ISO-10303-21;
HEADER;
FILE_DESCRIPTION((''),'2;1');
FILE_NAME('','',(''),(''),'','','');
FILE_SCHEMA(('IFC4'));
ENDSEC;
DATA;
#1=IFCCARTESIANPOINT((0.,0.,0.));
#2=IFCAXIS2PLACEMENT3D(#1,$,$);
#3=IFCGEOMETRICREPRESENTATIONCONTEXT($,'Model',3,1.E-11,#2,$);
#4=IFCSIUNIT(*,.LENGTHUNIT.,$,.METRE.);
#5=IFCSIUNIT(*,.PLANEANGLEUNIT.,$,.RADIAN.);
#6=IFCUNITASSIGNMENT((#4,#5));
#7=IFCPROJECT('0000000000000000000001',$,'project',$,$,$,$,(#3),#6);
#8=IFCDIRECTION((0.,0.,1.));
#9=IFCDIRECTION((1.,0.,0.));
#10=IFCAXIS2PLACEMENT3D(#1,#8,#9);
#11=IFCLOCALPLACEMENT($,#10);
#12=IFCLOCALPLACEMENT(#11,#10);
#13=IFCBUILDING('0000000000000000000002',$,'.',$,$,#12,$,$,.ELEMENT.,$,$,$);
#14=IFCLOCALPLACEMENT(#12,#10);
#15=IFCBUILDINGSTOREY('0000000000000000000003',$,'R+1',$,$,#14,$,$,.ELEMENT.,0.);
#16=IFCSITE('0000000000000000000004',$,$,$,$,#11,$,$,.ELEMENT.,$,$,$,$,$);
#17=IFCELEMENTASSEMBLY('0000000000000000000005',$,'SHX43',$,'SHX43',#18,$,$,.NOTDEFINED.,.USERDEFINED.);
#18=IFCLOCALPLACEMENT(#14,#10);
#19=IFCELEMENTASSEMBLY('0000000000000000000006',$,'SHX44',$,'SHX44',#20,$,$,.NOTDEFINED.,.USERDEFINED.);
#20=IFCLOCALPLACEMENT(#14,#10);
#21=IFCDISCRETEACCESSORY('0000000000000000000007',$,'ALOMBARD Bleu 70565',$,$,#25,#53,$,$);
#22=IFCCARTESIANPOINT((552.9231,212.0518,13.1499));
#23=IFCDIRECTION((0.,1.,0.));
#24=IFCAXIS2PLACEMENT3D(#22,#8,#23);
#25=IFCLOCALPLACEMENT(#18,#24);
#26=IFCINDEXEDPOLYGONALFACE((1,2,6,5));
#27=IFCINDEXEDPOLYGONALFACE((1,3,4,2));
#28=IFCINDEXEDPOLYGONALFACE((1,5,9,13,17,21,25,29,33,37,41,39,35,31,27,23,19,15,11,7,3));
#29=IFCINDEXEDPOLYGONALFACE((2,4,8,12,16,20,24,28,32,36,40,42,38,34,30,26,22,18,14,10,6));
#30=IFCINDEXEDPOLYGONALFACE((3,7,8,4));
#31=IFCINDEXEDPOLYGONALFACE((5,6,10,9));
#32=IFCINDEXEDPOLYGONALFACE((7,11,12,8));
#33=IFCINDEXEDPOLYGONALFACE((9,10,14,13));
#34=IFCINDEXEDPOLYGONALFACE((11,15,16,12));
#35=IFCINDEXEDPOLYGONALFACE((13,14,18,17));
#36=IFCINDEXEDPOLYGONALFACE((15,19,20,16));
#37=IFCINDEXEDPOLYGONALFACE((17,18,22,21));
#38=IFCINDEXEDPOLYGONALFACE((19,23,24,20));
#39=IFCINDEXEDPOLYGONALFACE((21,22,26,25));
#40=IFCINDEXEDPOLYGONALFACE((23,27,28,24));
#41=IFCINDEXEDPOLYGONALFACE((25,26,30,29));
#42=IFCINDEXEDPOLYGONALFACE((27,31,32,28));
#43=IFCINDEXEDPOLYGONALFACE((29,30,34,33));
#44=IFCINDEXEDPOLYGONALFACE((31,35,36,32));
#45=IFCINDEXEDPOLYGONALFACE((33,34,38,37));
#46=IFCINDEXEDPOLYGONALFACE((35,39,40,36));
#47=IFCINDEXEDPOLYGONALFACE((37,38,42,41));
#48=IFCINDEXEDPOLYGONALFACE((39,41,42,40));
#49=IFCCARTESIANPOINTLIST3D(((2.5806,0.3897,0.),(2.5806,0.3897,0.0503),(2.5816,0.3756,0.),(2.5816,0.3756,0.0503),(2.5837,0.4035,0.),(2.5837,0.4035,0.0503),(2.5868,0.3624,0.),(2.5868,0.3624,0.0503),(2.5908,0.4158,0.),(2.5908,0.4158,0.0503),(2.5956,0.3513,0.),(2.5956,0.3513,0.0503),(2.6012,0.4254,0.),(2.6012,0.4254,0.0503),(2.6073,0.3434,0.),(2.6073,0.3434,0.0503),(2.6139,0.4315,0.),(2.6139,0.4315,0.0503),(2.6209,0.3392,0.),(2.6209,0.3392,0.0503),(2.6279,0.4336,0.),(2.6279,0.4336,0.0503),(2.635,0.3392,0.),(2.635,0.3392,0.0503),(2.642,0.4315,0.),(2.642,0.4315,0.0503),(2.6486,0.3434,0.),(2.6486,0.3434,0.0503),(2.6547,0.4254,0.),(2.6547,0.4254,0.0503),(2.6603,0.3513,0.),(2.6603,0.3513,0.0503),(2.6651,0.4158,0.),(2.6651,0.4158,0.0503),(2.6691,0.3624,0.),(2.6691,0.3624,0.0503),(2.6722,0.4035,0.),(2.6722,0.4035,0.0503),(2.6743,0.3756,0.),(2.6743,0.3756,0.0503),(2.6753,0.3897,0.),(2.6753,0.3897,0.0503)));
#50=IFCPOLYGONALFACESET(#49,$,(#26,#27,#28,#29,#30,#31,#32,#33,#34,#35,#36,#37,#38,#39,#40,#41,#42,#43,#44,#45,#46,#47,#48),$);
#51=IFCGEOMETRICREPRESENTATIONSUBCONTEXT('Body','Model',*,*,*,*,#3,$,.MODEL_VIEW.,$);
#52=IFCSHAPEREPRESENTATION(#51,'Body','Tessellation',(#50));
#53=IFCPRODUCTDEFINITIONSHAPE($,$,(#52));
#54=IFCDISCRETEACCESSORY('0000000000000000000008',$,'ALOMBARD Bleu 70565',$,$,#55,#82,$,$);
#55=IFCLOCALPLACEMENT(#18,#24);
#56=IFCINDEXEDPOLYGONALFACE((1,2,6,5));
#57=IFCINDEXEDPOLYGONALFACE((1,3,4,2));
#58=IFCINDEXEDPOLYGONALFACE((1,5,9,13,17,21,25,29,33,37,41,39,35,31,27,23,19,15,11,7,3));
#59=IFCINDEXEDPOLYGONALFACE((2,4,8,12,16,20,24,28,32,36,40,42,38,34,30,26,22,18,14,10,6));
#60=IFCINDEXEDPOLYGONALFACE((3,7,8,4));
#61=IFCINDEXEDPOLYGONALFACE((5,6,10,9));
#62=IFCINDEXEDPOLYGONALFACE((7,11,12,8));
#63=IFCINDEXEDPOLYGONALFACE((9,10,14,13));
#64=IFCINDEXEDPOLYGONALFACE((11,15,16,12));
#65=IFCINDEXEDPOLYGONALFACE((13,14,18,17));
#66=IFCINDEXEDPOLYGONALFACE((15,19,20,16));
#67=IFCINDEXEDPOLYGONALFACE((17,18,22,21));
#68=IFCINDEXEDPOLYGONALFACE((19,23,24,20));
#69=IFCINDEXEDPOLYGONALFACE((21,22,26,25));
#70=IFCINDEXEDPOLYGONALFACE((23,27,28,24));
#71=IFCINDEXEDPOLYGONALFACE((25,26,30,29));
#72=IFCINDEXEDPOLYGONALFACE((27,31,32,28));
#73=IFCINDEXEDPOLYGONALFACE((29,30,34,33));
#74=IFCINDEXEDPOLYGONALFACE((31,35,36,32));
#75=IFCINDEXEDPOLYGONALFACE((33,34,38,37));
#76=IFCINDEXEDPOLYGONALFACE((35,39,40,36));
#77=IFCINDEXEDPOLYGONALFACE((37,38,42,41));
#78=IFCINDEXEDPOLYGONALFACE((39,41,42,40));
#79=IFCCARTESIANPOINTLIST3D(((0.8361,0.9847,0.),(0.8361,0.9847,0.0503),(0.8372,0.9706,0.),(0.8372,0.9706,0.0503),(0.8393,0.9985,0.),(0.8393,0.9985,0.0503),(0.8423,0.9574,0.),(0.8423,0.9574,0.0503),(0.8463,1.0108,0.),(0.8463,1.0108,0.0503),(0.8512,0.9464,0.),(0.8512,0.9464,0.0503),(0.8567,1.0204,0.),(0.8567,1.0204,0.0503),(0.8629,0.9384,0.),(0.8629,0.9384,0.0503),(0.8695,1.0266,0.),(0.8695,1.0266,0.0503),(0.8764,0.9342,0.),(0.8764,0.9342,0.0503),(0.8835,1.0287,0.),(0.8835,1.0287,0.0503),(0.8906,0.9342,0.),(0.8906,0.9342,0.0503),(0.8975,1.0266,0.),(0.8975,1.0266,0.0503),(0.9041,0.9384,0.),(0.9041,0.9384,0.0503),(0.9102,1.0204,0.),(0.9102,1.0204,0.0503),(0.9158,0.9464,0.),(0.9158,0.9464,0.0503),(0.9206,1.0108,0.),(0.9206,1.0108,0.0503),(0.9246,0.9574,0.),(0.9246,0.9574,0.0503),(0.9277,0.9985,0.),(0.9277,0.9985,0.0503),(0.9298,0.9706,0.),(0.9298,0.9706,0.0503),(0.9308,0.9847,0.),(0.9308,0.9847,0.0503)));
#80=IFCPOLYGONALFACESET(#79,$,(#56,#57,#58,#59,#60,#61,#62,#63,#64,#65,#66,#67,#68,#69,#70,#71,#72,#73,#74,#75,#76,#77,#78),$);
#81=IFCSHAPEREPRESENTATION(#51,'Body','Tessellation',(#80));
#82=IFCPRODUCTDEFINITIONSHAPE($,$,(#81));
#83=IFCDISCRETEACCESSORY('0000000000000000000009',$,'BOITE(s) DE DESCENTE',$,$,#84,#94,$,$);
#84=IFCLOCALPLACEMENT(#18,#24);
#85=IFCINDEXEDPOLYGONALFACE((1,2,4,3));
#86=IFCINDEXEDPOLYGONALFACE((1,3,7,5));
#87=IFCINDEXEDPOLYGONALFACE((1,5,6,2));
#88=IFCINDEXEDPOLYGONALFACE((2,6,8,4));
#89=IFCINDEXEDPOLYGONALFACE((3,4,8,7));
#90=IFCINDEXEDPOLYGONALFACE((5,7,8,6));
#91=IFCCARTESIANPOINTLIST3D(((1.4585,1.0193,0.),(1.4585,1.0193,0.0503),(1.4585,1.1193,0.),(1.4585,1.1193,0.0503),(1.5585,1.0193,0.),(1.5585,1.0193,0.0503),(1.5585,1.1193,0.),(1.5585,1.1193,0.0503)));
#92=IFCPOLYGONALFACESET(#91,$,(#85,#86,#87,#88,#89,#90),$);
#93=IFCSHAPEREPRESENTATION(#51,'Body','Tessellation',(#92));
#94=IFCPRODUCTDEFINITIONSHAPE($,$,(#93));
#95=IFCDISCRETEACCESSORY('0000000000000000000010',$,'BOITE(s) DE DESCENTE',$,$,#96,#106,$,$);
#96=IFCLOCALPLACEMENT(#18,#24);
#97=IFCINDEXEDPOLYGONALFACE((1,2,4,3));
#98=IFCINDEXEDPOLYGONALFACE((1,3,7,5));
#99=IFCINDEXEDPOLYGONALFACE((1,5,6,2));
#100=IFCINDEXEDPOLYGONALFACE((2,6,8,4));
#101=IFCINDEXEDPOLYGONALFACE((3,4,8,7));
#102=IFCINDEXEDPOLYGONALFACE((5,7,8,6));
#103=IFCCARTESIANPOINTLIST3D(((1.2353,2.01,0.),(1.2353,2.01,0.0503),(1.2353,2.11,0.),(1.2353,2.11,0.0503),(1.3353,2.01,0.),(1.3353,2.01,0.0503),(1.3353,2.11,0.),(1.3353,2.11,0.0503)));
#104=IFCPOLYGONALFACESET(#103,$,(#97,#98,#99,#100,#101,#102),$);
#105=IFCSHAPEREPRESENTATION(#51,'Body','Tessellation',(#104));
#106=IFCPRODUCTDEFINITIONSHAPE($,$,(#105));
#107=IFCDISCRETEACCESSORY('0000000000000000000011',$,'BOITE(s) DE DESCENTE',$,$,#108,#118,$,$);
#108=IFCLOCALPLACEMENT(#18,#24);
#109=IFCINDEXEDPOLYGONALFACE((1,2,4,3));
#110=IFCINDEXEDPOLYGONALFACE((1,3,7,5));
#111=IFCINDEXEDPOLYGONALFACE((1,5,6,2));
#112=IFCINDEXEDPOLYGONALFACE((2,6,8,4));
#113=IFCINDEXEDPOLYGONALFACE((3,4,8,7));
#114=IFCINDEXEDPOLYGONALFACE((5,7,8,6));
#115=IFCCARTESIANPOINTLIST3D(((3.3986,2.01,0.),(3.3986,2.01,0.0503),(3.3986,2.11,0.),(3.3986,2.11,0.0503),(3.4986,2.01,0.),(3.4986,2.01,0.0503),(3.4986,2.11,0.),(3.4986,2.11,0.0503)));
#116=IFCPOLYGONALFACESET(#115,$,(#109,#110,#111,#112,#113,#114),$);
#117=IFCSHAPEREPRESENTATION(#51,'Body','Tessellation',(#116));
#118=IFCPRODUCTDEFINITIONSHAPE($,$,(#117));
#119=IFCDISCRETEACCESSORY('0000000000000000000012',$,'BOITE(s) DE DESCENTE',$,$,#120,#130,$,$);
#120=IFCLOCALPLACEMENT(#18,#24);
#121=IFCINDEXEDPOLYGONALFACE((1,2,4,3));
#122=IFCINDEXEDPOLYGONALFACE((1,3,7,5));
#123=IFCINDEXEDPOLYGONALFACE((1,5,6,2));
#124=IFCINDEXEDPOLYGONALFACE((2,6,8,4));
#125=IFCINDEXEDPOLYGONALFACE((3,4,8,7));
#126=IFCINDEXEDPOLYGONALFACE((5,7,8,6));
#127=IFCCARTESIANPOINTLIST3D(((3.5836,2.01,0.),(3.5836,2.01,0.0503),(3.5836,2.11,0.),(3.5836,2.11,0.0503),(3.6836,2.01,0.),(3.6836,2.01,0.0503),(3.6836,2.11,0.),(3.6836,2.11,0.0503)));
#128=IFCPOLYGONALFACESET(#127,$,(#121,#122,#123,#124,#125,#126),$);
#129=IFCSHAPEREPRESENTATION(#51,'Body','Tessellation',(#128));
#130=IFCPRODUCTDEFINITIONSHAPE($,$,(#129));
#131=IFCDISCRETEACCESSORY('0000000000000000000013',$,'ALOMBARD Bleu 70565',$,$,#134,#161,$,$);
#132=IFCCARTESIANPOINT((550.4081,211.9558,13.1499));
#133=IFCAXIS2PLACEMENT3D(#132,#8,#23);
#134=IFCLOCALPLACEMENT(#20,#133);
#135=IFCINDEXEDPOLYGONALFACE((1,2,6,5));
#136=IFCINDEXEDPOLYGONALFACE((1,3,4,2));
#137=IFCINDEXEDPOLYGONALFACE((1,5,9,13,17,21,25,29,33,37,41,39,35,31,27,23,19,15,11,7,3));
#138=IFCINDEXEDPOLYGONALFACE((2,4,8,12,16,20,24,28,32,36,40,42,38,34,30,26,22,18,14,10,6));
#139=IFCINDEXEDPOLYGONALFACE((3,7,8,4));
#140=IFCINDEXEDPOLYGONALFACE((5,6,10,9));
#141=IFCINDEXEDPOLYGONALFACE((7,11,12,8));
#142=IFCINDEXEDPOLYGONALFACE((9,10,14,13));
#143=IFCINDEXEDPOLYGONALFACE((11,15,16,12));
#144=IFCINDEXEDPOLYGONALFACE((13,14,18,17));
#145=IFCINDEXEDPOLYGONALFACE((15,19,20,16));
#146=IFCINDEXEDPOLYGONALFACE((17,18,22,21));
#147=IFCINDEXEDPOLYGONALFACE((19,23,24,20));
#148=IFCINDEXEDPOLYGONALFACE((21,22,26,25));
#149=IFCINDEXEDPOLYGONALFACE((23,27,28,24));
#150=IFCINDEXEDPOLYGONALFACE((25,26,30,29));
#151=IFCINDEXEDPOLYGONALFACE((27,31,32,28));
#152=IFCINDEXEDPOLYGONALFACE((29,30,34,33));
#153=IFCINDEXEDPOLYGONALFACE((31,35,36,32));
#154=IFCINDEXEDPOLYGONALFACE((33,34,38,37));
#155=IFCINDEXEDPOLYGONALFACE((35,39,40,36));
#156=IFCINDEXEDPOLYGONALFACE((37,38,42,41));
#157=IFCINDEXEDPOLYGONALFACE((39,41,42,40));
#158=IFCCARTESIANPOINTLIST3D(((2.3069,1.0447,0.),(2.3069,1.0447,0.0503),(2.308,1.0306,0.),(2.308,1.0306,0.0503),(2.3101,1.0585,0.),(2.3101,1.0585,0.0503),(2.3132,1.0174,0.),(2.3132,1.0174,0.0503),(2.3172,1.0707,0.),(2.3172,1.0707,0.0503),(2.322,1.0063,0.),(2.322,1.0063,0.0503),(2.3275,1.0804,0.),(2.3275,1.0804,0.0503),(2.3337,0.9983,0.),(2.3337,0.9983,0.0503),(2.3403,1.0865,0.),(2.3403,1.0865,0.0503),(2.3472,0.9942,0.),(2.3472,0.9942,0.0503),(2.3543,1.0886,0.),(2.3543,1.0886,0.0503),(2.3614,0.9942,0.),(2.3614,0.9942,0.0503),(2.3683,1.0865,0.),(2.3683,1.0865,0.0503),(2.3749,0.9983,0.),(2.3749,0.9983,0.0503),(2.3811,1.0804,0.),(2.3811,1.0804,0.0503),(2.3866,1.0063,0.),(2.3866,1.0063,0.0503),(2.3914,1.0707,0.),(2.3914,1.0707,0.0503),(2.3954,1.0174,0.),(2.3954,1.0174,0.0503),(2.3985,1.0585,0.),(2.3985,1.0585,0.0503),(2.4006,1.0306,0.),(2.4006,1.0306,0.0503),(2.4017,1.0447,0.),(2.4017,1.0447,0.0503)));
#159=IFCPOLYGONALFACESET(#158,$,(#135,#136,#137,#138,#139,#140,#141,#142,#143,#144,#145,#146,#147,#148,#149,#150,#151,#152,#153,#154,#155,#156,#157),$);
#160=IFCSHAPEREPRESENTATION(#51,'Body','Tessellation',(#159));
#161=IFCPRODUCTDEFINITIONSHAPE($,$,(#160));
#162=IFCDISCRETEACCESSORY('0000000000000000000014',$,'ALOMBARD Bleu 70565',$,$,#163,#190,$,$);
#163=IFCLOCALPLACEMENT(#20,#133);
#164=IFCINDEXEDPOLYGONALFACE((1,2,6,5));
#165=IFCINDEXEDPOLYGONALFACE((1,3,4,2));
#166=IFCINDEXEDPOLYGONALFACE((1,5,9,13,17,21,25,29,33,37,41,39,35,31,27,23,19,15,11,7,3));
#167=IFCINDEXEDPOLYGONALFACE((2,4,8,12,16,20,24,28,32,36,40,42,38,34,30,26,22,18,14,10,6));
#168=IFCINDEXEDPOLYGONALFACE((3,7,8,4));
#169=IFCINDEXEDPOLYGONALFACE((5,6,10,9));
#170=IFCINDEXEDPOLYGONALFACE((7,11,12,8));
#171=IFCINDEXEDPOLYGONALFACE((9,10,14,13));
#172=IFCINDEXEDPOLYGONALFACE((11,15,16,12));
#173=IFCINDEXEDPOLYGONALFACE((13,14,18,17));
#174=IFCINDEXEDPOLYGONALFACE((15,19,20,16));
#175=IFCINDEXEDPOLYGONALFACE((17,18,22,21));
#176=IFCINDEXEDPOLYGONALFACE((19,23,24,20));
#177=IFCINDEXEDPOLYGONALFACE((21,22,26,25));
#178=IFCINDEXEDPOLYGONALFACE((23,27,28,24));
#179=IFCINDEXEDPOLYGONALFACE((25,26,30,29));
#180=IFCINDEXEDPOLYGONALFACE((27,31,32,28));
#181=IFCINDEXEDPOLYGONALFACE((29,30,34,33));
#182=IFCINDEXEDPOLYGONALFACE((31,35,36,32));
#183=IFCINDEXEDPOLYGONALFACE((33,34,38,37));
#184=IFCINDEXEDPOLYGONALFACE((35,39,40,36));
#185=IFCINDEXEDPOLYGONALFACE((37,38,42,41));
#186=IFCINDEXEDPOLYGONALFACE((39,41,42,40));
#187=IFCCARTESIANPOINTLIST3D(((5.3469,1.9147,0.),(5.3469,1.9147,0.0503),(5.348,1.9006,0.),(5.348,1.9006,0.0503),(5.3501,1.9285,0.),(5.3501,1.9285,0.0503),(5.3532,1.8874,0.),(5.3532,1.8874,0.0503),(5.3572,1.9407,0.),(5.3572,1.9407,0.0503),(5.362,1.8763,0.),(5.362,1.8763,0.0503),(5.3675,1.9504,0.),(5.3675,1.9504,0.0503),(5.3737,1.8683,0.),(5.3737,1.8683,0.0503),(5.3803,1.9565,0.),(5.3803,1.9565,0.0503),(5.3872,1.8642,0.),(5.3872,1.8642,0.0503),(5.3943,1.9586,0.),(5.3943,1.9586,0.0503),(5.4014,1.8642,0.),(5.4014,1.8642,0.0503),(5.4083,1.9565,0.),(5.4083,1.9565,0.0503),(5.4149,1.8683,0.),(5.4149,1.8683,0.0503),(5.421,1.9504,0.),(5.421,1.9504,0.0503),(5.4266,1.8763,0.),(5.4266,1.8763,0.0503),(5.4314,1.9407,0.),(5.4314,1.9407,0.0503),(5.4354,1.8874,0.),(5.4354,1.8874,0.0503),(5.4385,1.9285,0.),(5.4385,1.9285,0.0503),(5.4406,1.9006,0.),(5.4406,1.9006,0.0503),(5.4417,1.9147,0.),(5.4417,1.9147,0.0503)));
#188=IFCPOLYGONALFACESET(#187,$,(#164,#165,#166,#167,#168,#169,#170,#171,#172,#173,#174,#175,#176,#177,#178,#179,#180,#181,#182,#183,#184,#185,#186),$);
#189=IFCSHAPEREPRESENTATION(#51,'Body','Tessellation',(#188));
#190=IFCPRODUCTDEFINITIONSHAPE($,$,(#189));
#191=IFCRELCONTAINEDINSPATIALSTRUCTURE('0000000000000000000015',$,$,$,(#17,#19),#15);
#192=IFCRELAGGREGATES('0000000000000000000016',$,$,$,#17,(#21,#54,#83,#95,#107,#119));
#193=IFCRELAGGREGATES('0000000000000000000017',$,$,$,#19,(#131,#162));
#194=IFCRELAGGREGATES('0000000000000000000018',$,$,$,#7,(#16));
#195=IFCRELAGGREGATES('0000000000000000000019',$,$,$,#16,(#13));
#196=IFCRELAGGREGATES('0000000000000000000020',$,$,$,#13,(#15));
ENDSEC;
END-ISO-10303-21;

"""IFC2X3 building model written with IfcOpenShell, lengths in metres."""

from ifc_helpers import new_model, si_unit, frame, frame_2d, origin, origin_with_axes, place, context, subcontext, project, spatial, polyline, circle, outline, extrude, element, aggregate, save


model = new_model("IFC2X3")

# Units and contexts
model_context = context("Model", 3, precision=1e-11, world=origin())
body_context = subcontext(model_context, "Body", "Model", "MODEL_VIEW")
ifc_project = project(units=[si_unit("LENGTHUNIT", "METRE"), si_unit("PLANEANGLEUNIT", "RADIAN")], contexts=[model_context])

# Site, building, storey
site_placement = place(None, origin_with_axes())
site = spatial("IfcSite", under=ifc_project, at=site_placement, CompositionType="ELEMENT")
building_placement = place(site_placement, origin_with_axes())
building = spatial("IfcBuilding", under=site, at=building_placement, Name=".", CompositionType="ELEMENT")
storey_placement = place(building_placement, origin_with_axes())
storey = spatial("IfcBuildingStorey", under=building, at=storey_placement, Name="R+1", CompositionType="ELEMENT", Elevation=0.0)

# Element assemblies
assembly_1_placement = place(storey_placement, origin_with_axes())
assembly_1 = element("IfcElementAssembly", 1, at=assembly_1_placement, inside=storey, Name="SHX43", ObjectType="SHX43", AssemblyPlace="NOTDEFINED", PredefinedType="USERDEFINED")
assembly_2_placement = place(storey_placement, origin_with_axes())
assembly_2 = element("IfcElementAssembly", 2, at=assembly_2_placement, inside=storey, Name="SHX44", ObjectType="SHX44", AssemblyPlace="NOTDEFINED", PredefinedType="USERDEFINED")

# Discrete accessories
discrete_accessory_1_placement = place(assembly_1_placement, frame((552.9231, 212.0518, 13.1499), z_axis=(0.0, 0.0, 1.0), x_axis=(0.0, 1.0, 0.0)))
discrete_accessory_1 = element("IfcDiscreteAccessory", 3, at=discrete_accessory_1_placement, Name="ALOMBARD Bleu 70565", context=body_context, shape_type="SweptSolid", body=[
    extrude(circle(Radius=0.0475, at=frame_2d((0.3861, -2.6279), x_axis=(1.0, 0.0))), frame((0.0, 0.0, 0.0), z_axis=(0.0, 0.0, 1.0), x_axis=(0.0, 1.0, 0.0)), (0.0, 0.0, 1.0), 0.0503),
])
discrete_accessory_2_placement = place(assembly_1_placement, frame((552.9231, 212.0518, 13.1499), z_axis=(0.0, 0.0, 1.0), x_axis=(0.0, 1.0, 0.0)))
discrete_accessory_2 = element("IfcDiscreteAccessory", 4, at=discrete_accessory_2_placement, Name="ALOMBARD Bleu 70565", context=body_context, shape_type="SweptSolid", body=[
    extrude(circle(Radius=0.0475, at=frame_2d((0.9812, -0.8835), x_axis=(1.0, 0.0))), frame((0.0, 0.0, 0.0), z_axis=(0.0, 0.0, 1.0), x_axis=(0.0, 1.0, 0.0)), (0.0, 0.0, 1.0), 0.0503),
])
discrete_accessory_3_placement = place(assembly_1_placement, frame((552.9231, 212.0518, 13.1499), z_axis=(0.0, 0.0, 1.0), x_axis=(0.0, 1.0, 0.0)))
discrete_accessory_3 = element("IfcDiscreteAccessory", 5, at=discrete_accessory_3_placement, Name="BOITE(s) DE DESCENTE", context=body_context, shape_type="SweptSolid", body=[
    extrude(outline(polyline([(1.0193, -1.4585), (1.0193, -1.5585), (1.1193, -1.5585), (1.1193, -1.4585), (1.0193, -1.4585)])), frame((0.0, 0.0, 0.0), z_axis=(0.0, 0.0, 1.0), x_axis=(0.0, 1.0, 0.0)), (0.0, 0.0, 1.0), 0.0503),
])
discrete_accessory_4_placement = place(assembly_1_placement, frame((552.9231, 212.0518, 13.1499), z_axis=(0.0, 0.0, 1.0), x_axis=(0.0, 1.0, 0.0)))
discrete_accessory_4 = element("IfcDiscreteAccessory", 6, at=discrete_accessory_4_placement, Name="BOITE(s) DE DESCENTE", context=body_context, shape_type="SweptSolid", body=[
    extrude(outline(polyline([(2.01, -1.2353), (2.01, -1.3353), (2.11, -1.3353), (2.11, -1.2353), (2.01, -1.2353)])), frame((0.0, 0.0, 0.0), z_axis=(0.0, 0.0, 1.0), x_axis=(0.0, 1.0, 0.0)), (0.0, 0.0, 1.0), 0.0503),
])
discrete_accessory_5_placement = place(assembly_1_placement, frame((552.9231, 212.0518, 13.1499), z_axis=(0.0, 0.0, 1.0), x_axis=(0.0, 1.0, 0.0)))
discrete_accessory_5 = element("IfcDiscreteAccessory", 7, at=discrete_accessory_5_placement, Name="BOITE(s) DE DESCENTE", context=body_context, shape_type="SweptSolid", body=[
    extrude(outline(polyline([(2.01, -3.3986), (2.01, -3.4986), (2.11, -3.4986), (2.11, -3.3986), (2.01, -3.3986)])), frame((0.0, 0.0, 0.0), z_axis=(0.0, 0.0, 1.0), x_axis=(0.0, 1.0, 0.0)), (0.0, 0.0, 1.0), 0.0503),
])
discrete_accessory_6_placement = place(assembly_1_placement, frame((552.9231, 212.0518, 13.1499), z_axis=(0.0, 0.0, 1.0), x_axis=(0.0, 1.0, 0.0)))
discrete_accessory_6 = element("IfcDiscreteAccessory", 8, at=discrete_accessory_6_placement, Name="BOITE(s) DE DESCENTE", context=body_context, shape_type="SweptSolid", body=[
    extrude(outline(polyline([(2.01, -3.5836), (2.01, -3.6836), (2.11, -3.6836), (2.11, -3.5836), (2.01, -3.5836)])), frame((0.0, 0.0, 0.0), z_axis=(0.0, 0.0, 1.0), x_axis=(0.0, 1.0, 0.0)), (0.0, 0.0, 1.0), 0.0503),
])

aggregate(assembly_1, [discrete_accessory_1, discrete_accessory_2, discrete_accessory_3, discrete_accessory_4, discrete_accessory_5, discrete_accessory_6])

# Discrete accessories
discrete_accessory_7_placement = place(assembly_2_placement, frame((550.4081, 211.9558, 13.1499), z_axis=(0.0, 0.0, 1.0), x_axis=(0.0, 1.0, 0.0)))
discrete_accessory_7 = element("IfcDiscreteAccessory", 9, at=discrete_accessory_7_placement, Name="ALOMBARD Bleu 70565", context=body_context, shape_type="SweptSolid", body=[
    extrude(circle(Radius=0.0475, at=frame_2d((1.0411, -2.3543), x_axis=(1.0, 0.0))), frame((0.0, 0.0, 0.0), z_axis=(0.0, 0.0, 1.0), x_axis=(0.0, 1.0, 0.0)), (0.0, 0.0, 1.0), 0.0503),
])
discrete_accessory_8_placement = place(assembly_2_placement, frame((550.4081, 211.9558, 13.1499), z_axis=(0.0, 0.0, 1.0), x_axis=(0.0, 1.0, 0.0)))
discrete_accessory_8 = element("IfcDiscreteAccessory", 10, at=discrete_accessory_8_placement, Name="ALOMBARD Bleu 70565", context=body_context, shape_type="SweptSolid", body=[
    extrude(circle(Radius=0.0475, at=frame_2d((1.9111, -5.3943), x_axis=(1.0, 0.0))), frame((0.0, 0.0, 0.0), z_axis=(0.0, 0.0, 1.0), x_axis=(0.0, 1.0, 0.0)), (0.0, 0.0, 1.0), 0.0503),
])

aggregate(assembly_2, [discrete_accessory_7, discrete_accessory_8])

save(model, "model.ifc")
